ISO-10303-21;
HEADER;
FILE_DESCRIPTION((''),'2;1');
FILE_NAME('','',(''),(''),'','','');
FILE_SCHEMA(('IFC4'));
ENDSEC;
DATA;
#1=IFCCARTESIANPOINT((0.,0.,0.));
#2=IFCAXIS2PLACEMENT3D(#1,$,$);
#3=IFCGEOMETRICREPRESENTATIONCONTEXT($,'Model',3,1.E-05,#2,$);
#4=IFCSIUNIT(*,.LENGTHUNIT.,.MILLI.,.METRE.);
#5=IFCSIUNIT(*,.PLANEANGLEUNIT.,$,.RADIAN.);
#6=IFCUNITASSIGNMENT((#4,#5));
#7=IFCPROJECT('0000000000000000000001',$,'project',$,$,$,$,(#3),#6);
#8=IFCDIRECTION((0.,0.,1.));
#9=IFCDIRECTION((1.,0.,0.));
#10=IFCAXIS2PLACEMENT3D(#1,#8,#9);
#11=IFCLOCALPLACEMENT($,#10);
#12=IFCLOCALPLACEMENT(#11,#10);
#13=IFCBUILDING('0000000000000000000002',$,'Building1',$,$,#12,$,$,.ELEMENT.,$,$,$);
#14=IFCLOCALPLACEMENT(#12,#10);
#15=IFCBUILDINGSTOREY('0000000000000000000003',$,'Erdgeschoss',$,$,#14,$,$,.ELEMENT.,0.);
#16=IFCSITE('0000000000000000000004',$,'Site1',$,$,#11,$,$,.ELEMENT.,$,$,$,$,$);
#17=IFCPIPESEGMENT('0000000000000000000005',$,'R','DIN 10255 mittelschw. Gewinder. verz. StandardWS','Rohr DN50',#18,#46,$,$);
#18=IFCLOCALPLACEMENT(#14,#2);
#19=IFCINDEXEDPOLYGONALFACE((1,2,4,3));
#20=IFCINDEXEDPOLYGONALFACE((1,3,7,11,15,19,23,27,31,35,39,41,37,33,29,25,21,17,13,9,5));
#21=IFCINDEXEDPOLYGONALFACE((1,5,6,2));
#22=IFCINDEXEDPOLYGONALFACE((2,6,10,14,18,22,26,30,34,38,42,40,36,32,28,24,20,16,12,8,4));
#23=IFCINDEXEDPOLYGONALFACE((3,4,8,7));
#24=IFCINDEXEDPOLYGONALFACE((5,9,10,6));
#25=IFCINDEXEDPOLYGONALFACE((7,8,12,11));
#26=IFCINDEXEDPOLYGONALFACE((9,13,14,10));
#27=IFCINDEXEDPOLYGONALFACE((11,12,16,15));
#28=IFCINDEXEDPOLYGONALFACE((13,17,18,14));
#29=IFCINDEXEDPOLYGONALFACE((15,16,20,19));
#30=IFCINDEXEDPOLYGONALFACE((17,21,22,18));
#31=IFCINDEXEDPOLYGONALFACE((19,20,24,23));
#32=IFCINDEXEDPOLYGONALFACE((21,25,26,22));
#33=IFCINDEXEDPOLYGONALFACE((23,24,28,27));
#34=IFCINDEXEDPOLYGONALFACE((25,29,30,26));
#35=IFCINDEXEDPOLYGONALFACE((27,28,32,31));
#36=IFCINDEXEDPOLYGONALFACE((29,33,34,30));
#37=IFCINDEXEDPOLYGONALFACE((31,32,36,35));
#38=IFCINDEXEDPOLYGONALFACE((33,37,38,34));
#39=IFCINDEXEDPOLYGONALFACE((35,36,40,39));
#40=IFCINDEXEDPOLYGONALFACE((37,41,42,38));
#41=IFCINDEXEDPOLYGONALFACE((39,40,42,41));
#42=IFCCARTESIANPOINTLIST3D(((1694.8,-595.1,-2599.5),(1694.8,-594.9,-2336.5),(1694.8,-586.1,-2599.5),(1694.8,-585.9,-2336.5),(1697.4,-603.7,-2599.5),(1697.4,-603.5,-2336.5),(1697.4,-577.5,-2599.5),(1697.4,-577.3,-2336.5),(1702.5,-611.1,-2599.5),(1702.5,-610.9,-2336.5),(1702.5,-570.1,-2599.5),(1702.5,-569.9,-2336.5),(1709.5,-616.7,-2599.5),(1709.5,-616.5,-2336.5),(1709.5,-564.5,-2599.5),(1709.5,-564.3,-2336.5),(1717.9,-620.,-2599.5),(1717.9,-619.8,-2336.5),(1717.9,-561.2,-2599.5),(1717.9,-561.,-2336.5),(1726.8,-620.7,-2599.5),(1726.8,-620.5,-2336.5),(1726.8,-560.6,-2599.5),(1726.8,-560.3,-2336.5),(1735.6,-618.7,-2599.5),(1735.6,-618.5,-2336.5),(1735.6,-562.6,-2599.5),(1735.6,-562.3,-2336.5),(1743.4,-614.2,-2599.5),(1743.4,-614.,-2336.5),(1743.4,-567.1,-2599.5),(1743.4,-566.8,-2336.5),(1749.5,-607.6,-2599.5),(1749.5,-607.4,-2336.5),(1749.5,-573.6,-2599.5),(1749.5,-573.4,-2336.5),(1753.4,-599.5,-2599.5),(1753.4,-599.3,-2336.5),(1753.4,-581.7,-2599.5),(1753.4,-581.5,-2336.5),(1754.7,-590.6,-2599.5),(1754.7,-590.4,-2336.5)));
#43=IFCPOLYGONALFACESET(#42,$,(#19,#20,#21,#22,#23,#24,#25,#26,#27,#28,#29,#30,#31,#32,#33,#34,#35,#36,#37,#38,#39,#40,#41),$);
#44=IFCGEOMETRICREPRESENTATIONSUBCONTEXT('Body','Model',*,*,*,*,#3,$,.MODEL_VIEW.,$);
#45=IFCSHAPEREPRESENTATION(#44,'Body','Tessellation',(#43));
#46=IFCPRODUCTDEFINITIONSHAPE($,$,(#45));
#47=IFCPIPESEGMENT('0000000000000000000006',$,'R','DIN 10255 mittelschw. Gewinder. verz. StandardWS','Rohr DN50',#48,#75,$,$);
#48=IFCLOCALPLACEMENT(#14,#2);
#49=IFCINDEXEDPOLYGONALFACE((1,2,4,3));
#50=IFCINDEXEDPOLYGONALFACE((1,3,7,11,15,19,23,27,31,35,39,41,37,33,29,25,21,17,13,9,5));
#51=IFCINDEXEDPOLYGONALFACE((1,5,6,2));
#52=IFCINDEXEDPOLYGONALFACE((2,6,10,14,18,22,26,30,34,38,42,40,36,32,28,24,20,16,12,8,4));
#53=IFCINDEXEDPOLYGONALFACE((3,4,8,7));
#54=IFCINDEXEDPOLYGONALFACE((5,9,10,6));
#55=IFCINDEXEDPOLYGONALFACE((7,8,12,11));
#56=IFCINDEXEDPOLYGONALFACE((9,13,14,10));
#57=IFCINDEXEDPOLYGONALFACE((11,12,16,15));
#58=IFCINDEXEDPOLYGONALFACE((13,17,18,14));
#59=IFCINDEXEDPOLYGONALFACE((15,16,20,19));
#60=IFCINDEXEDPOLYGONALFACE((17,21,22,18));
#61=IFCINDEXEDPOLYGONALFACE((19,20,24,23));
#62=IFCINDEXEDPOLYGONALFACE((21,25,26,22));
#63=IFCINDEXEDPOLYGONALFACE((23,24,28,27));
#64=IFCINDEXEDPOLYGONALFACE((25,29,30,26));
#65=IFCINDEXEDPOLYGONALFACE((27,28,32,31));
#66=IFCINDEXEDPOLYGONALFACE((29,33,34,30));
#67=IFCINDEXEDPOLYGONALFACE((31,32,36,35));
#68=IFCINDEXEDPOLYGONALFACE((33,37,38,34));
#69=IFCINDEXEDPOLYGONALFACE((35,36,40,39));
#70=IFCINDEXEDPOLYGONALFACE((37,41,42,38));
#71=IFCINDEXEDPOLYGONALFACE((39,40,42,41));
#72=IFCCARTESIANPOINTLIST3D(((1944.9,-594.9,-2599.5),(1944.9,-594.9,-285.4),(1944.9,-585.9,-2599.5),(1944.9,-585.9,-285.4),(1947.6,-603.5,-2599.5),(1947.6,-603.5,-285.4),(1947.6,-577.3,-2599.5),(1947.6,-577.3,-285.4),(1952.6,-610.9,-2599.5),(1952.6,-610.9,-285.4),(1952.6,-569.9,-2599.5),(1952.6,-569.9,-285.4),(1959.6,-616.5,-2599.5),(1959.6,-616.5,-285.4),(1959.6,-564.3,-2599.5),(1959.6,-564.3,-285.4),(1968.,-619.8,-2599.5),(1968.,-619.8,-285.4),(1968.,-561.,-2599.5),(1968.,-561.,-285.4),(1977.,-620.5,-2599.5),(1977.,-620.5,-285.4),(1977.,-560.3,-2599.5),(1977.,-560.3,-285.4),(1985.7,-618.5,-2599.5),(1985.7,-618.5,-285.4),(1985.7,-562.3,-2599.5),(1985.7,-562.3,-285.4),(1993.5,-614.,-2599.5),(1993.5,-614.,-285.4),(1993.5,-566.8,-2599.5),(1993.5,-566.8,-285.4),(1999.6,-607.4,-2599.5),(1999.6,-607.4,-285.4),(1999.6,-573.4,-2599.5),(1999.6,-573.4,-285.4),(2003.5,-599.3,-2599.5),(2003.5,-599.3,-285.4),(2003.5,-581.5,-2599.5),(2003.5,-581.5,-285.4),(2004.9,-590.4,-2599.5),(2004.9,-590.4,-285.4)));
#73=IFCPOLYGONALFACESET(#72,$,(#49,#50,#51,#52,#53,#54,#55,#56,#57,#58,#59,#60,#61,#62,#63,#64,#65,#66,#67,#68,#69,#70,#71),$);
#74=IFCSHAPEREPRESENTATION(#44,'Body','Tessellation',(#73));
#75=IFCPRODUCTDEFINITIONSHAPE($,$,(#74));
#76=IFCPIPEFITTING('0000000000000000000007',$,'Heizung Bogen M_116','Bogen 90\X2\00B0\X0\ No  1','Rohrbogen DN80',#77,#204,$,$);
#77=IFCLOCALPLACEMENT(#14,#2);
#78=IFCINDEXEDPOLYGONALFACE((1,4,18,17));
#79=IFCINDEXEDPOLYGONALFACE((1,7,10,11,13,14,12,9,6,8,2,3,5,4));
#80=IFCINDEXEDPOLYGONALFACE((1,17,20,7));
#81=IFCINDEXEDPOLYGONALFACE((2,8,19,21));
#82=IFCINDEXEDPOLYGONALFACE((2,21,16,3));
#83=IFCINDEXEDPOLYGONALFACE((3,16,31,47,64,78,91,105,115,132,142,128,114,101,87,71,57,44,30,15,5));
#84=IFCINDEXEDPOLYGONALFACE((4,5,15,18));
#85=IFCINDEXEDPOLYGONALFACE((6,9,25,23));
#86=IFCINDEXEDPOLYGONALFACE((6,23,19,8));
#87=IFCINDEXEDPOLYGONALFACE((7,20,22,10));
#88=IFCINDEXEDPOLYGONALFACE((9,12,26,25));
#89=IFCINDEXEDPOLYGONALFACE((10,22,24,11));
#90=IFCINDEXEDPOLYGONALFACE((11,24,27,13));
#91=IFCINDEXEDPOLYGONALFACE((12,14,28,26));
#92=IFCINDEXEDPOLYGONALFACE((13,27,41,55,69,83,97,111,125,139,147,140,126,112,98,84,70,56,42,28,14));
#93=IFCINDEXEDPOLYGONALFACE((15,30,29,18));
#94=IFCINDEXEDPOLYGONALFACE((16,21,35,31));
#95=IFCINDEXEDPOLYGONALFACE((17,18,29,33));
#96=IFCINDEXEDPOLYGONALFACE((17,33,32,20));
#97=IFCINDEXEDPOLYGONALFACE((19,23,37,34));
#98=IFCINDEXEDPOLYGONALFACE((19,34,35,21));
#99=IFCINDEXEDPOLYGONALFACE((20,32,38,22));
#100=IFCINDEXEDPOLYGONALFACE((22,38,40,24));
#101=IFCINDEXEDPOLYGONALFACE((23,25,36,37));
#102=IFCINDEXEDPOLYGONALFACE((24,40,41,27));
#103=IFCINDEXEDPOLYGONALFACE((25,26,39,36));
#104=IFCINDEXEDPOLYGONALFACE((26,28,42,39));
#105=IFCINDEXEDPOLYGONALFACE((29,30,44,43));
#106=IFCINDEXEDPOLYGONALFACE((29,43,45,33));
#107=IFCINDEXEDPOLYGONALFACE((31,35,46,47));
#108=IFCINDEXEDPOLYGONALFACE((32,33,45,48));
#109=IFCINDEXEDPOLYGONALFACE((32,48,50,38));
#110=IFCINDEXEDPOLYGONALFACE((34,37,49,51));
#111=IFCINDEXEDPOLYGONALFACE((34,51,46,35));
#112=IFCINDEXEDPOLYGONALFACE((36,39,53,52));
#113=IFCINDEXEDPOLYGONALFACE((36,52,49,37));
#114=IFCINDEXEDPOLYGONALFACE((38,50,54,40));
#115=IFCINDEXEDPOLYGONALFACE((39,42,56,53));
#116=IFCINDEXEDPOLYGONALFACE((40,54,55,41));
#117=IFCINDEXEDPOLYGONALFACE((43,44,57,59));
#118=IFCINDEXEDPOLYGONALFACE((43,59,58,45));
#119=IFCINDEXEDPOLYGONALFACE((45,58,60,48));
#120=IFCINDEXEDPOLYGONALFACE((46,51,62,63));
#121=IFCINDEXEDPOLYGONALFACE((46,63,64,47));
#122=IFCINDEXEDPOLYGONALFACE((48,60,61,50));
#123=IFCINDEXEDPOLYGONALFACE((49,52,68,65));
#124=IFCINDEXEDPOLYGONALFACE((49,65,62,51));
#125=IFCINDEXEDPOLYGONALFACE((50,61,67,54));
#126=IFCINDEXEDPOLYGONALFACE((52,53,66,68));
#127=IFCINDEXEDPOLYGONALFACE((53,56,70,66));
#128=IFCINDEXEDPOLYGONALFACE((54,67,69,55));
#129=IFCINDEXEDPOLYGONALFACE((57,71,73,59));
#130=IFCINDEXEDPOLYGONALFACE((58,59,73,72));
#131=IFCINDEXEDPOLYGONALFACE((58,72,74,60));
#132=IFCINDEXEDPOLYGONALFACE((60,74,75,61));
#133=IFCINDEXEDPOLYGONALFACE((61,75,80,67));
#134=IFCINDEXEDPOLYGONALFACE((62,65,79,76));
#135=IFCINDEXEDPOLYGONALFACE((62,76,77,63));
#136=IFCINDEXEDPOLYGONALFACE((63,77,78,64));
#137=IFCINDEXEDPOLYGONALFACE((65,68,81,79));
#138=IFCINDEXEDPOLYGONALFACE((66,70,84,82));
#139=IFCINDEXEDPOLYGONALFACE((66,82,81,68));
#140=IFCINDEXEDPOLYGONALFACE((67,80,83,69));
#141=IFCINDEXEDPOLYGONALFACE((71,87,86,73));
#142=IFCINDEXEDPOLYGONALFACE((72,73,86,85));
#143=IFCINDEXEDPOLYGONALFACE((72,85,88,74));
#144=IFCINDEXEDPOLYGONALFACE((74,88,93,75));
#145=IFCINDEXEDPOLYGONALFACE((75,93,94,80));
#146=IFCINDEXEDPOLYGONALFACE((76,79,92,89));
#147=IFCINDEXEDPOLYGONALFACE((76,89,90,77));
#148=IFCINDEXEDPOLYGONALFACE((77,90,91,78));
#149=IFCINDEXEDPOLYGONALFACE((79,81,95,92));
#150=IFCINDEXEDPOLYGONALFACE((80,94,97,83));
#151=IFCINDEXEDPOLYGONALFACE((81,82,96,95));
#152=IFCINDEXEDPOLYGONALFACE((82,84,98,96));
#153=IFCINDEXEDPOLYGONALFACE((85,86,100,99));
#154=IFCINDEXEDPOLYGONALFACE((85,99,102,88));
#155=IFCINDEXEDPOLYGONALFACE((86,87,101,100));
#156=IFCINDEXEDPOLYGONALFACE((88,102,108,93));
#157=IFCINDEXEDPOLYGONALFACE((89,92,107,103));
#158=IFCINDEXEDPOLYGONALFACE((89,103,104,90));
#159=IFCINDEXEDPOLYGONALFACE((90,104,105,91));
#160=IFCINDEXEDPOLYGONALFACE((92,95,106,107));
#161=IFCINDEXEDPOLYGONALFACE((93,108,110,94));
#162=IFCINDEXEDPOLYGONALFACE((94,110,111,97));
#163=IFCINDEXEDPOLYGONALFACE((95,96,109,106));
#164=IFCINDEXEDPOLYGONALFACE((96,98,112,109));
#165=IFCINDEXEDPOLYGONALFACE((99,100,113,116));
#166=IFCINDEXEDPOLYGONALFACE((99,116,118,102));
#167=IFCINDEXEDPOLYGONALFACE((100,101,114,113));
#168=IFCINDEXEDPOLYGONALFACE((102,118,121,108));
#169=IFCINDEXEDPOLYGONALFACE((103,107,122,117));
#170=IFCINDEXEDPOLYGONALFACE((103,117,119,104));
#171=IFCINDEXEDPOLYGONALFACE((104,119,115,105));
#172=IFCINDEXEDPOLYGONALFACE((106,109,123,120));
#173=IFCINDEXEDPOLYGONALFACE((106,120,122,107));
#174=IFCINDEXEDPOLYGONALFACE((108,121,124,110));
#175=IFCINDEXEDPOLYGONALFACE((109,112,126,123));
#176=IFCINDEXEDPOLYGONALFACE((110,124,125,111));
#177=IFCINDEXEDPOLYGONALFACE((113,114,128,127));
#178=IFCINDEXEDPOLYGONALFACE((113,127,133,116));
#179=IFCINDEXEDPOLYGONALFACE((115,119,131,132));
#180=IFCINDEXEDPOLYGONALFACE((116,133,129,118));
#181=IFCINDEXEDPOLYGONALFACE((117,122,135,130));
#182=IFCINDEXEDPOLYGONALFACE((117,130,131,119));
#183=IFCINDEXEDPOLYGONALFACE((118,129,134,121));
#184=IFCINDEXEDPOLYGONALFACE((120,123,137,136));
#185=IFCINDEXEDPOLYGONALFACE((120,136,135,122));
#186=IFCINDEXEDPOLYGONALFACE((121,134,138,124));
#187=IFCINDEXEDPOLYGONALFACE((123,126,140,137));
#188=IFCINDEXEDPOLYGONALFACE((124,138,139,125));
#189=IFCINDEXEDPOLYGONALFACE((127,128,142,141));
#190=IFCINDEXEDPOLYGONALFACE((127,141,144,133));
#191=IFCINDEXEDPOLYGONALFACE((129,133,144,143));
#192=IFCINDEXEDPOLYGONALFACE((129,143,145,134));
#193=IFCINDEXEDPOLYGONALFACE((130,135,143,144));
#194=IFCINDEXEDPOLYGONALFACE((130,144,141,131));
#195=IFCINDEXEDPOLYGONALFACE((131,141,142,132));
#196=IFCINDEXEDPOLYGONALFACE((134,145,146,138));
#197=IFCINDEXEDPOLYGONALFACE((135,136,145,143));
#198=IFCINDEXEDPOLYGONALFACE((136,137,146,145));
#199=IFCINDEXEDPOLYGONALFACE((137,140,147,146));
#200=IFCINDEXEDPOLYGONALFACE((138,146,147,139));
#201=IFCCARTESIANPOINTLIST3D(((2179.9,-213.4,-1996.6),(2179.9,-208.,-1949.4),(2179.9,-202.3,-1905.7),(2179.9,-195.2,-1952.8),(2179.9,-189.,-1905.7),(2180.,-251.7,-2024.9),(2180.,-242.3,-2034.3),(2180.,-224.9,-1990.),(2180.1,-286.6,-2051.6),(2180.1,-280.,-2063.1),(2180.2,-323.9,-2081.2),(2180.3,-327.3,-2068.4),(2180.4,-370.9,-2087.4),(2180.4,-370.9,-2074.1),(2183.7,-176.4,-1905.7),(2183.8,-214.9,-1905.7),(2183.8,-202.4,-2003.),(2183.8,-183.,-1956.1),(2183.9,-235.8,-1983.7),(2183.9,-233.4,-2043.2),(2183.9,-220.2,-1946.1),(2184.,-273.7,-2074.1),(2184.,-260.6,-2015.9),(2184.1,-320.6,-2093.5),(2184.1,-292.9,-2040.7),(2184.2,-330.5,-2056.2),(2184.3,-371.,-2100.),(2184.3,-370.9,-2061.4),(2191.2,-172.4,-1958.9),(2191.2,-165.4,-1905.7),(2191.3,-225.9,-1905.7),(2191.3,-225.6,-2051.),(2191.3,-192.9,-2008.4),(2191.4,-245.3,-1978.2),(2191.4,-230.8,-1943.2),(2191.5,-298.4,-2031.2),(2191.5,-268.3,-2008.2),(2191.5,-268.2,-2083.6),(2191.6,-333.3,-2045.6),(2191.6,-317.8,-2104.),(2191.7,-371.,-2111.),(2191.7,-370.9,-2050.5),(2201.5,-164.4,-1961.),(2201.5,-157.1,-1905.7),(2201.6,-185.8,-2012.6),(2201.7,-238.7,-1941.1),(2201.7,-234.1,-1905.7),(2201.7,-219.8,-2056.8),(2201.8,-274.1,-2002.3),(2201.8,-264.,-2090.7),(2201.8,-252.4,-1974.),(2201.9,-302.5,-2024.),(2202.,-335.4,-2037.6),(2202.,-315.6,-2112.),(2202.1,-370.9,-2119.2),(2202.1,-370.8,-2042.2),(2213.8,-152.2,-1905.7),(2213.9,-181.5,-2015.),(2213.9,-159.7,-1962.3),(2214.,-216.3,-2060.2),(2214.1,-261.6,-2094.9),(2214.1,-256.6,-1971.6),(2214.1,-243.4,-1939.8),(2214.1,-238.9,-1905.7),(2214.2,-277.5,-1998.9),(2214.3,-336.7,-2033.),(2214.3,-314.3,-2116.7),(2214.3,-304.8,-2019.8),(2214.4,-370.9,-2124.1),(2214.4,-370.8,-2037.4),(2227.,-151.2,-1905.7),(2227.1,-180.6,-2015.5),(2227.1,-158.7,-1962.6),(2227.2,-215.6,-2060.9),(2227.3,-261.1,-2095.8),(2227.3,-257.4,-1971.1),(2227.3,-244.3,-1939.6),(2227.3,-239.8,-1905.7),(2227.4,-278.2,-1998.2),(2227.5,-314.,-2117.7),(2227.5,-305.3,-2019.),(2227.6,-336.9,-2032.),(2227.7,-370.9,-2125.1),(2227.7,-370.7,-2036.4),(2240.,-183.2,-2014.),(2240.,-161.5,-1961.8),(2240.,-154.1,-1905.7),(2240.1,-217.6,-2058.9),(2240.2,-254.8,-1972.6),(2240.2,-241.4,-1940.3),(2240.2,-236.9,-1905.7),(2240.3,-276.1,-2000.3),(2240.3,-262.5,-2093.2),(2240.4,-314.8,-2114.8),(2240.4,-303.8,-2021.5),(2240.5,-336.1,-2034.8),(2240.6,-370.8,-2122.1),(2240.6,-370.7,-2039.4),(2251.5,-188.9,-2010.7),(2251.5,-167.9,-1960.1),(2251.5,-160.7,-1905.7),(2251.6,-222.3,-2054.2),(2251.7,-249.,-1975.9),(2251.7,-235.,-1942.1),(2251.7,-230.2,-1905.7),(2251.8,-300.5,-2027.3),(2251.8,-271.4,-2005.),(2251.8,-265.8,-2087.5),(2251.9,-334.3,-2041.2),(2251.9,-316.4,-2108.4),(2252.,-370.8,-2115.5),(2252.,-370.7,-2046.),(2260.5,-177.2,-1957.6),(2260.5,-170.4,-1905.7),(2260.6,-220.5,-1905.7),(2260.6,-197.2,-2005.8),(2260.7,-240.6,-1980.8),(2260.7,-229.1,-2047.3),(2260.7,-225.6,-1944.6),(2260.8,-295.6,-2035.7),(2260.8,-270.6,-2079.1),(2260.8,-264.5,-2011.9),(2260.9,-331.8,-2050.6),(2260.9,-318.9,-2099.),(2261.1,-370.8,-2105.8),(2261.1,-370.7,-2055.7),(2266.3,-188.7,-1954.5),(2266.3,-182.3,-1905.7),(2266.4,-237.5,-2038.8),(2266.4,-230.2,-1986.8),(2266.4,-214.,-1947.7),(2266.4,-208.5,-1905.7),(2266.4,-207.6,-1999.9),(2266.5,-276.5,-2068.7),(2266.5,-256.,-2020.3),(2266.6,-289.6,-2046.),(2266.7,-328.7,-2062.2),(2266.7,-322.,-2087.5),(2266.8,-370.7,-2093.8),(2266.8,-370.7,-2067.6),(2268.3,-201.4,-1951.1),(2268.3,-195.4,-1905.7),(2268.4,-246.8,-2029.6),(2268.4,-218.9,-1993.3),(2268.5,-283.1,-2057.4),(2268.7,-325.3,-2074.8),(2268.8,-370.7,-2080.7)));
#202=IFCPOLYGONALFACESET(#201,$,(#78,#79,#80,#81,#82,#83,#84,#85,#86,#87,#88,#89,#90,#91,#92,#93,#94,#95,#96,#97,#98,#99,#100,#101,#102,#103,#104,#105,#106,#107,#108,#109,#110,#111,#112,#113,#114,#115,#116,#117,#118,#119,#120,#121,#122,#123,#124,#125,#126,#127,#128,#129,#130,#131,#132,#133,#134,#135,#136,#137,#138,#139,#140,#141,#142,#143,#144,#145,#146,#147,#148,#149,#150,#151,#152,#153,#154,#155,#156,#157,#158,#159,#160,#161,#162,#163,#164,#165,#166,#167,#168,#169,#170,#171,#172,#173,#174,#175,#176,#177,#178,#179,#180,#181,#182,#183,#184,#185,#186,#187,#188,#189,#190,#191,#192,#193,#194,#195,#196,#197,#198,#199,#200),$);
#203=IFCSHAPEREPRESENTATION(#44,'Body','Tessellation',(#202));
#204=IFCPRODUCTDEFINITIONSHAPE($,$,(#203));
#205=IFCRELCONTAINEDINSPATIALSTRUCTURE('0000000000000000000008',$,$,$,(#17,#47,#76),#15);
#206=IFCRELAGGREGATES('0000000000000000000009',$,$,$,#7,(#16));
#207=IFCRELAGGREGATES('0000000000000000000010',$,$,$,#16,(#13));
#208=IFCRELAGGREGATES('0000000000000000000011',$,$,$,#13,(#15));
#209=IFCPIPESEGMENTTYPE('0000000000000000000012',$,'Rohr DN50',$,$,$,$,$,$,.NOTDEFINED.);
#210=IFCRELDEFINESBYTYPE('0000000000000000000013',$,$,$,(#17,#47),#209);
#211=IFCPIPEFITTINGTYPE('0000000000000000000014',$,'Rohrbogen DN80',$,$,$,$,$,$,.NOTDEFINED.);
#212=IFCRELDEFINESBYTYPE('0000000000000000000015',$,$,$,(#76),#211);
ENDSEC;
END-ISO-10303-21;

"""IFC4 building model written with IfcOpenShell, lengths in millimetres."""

from ifc_helpers import new_model, entity, si_unit, frame, origin, origin_with_axes, origin_2d_with_axis, place, context, subcontext, project, spatial, circle, extrude, source, transform, mapped, type_object, element, save


model = new_model("IFC4")

# Units and contexts
model_context = context("Model", 3, precision=1e-05, world=origin())
body_context = subcontext(model_context, "Body", "Model", "MODEL_VIEW")
ifc_project = project(units=[si_unit("LENGTHUNIT", "METRE", prefix="MILLI"), si_unit("PLANEANGLEUNIT", "RADIAN")], contexts=[model_context])

# Site, building, storey
site_placement = place(None, origin_with_axes())
site = spatial("IfcSite", under=ifc_project, at=site_placement, Name="Site1", CompositionType="ELEMENT")
building_placement = place(site_placement, origin_with_axes())
building = spatial("IfcBuilding", under=site, at=building_placement, Name="Building1", CompositionType="ELEMENT")
storey_placement = place(building_placement, origin_with_axes())
storey = spatial("IfcBuildingStorey", under=building, at=storey_placement, Name="Erdgeschoss", CompositionType="ELEMENT", Elevation=0.0)

# Pipe segments
pipe_segment_type_1 = type_object("IfcPipeSegmentType", Name="Rohr DN50", PredefinedType="NOTDEFINED")
pipe_segment_1_placement = place(storey_placement, frame((1724.6, -590.7, -2468.0), z_axis=(0.0, 0.0, 1.0), x_axis=(1.0, 0.0, 0.0)))
element("IfcPipeSegment", 1, at=pipe_segment_1_placement, inside=storey, type_object=pipe_segment_type_1, Name="R", Description="DIN 10255 mittelschw. Gewinder. verz. StandardWS", ObjectType="Rohr DN50", context=body_context, shape_type="SolidModel", body=[
    extrude(circle(Radius=30.1, at=origin_2d_with_axis()), frame((0.0, 0.0, -131.5), z_axis=(0.0, 0.000808, 1.0), x_axis=(1.0, 0.0, 0.0)), (0.0, 0.0, 1.0), 263.0),
])
pipe_segment_2_placement = place(storey_placement, frame((1974.7, -590.6, -1442.4), z_axis=(0.0, 0.0, 1.0), x_axis=(1.0, 0.0, 0.0)))
element("IfcPipeSegment", 2, at=pipe_segment_2_placement, inside=storey, type_object=pipe_segment_type_1, Name="R", Description="DIN 10255 mittelschw. Gewinder. verz. StandardWS", ObjectType="Rohr DN50", context=body_context, shape_type="SolidModel", body=[
    extrude(circle(Radius=30.1, at=origin_2d_with_axis()), frame((0.0, 0.1, -1157.1), z_axis=(0.0, 0.0, 1.0), x_axis=(1.0, 0.0, 0.0)), (0.0, 0.0, 1.0), 2314.1),
])

# Pipe fitting
pipe_fitting_type_1 = type_object("IfcPipeFittingType", Name="Rohrbogen DN80", PredefinedType="NOTDEFINED")
shared_shape_1 = source(origin_with_axes(), body_context, "Body", "SolidModel", [
    entity("IfcRevolvedAreaSolid", entity("IfcCircleProfileDef", "AREA", None, entity("IfcAxis2Placement2D", entity("IfcCartesianPoint", [0.0, 0.0]), entity("IfcDirection", [1.0, 0.0])), 44.5), entity("IfcAxis2Placement3D", entity("IfcCartesianPoint", [109.7, -0.2, 65.5]), entity("IfcDirection", [-1.0, 0.0, 0.0]), entity("IfcDirection", [0.0, 0.999996, 0.002779])), entity("IfcAxis1Placement", entity("IfcCartesianPoint", [0.0, 175.0, 0.0]), entity("IfcDirection", [-1.0, 0.0, 0.0])), 1.572437),
])
pipe_fitting_1_placement = place(storey_placement, frame((2224.0, -261.0, -2015.5), z_axis=(0.0, 0.0, 1.0), x_axis=(1.0, 0.0, 0.0)))
element("IfcPipeFitting", 3, at=pipe_fitting_1_placement, inside=storey, type_object=pipe_fitting_type_1, Name="Heizung Bogen M_116", Description="Bogen 90° No  1", ObjectType="Rohrbogen DN80", context=body_context, shape_type="MappedRepresentation", body=[
    mapped(shared_shape_1, transform((0.0, 0.0, 0.0), x_axis=(0.0, 0.0, 1.0), y_axis=(1.0, 0.0, 0.0), z_axis=(0.0, 1.0, 0.0), scale=1.0)),
])

save(model, "model.ifc")
